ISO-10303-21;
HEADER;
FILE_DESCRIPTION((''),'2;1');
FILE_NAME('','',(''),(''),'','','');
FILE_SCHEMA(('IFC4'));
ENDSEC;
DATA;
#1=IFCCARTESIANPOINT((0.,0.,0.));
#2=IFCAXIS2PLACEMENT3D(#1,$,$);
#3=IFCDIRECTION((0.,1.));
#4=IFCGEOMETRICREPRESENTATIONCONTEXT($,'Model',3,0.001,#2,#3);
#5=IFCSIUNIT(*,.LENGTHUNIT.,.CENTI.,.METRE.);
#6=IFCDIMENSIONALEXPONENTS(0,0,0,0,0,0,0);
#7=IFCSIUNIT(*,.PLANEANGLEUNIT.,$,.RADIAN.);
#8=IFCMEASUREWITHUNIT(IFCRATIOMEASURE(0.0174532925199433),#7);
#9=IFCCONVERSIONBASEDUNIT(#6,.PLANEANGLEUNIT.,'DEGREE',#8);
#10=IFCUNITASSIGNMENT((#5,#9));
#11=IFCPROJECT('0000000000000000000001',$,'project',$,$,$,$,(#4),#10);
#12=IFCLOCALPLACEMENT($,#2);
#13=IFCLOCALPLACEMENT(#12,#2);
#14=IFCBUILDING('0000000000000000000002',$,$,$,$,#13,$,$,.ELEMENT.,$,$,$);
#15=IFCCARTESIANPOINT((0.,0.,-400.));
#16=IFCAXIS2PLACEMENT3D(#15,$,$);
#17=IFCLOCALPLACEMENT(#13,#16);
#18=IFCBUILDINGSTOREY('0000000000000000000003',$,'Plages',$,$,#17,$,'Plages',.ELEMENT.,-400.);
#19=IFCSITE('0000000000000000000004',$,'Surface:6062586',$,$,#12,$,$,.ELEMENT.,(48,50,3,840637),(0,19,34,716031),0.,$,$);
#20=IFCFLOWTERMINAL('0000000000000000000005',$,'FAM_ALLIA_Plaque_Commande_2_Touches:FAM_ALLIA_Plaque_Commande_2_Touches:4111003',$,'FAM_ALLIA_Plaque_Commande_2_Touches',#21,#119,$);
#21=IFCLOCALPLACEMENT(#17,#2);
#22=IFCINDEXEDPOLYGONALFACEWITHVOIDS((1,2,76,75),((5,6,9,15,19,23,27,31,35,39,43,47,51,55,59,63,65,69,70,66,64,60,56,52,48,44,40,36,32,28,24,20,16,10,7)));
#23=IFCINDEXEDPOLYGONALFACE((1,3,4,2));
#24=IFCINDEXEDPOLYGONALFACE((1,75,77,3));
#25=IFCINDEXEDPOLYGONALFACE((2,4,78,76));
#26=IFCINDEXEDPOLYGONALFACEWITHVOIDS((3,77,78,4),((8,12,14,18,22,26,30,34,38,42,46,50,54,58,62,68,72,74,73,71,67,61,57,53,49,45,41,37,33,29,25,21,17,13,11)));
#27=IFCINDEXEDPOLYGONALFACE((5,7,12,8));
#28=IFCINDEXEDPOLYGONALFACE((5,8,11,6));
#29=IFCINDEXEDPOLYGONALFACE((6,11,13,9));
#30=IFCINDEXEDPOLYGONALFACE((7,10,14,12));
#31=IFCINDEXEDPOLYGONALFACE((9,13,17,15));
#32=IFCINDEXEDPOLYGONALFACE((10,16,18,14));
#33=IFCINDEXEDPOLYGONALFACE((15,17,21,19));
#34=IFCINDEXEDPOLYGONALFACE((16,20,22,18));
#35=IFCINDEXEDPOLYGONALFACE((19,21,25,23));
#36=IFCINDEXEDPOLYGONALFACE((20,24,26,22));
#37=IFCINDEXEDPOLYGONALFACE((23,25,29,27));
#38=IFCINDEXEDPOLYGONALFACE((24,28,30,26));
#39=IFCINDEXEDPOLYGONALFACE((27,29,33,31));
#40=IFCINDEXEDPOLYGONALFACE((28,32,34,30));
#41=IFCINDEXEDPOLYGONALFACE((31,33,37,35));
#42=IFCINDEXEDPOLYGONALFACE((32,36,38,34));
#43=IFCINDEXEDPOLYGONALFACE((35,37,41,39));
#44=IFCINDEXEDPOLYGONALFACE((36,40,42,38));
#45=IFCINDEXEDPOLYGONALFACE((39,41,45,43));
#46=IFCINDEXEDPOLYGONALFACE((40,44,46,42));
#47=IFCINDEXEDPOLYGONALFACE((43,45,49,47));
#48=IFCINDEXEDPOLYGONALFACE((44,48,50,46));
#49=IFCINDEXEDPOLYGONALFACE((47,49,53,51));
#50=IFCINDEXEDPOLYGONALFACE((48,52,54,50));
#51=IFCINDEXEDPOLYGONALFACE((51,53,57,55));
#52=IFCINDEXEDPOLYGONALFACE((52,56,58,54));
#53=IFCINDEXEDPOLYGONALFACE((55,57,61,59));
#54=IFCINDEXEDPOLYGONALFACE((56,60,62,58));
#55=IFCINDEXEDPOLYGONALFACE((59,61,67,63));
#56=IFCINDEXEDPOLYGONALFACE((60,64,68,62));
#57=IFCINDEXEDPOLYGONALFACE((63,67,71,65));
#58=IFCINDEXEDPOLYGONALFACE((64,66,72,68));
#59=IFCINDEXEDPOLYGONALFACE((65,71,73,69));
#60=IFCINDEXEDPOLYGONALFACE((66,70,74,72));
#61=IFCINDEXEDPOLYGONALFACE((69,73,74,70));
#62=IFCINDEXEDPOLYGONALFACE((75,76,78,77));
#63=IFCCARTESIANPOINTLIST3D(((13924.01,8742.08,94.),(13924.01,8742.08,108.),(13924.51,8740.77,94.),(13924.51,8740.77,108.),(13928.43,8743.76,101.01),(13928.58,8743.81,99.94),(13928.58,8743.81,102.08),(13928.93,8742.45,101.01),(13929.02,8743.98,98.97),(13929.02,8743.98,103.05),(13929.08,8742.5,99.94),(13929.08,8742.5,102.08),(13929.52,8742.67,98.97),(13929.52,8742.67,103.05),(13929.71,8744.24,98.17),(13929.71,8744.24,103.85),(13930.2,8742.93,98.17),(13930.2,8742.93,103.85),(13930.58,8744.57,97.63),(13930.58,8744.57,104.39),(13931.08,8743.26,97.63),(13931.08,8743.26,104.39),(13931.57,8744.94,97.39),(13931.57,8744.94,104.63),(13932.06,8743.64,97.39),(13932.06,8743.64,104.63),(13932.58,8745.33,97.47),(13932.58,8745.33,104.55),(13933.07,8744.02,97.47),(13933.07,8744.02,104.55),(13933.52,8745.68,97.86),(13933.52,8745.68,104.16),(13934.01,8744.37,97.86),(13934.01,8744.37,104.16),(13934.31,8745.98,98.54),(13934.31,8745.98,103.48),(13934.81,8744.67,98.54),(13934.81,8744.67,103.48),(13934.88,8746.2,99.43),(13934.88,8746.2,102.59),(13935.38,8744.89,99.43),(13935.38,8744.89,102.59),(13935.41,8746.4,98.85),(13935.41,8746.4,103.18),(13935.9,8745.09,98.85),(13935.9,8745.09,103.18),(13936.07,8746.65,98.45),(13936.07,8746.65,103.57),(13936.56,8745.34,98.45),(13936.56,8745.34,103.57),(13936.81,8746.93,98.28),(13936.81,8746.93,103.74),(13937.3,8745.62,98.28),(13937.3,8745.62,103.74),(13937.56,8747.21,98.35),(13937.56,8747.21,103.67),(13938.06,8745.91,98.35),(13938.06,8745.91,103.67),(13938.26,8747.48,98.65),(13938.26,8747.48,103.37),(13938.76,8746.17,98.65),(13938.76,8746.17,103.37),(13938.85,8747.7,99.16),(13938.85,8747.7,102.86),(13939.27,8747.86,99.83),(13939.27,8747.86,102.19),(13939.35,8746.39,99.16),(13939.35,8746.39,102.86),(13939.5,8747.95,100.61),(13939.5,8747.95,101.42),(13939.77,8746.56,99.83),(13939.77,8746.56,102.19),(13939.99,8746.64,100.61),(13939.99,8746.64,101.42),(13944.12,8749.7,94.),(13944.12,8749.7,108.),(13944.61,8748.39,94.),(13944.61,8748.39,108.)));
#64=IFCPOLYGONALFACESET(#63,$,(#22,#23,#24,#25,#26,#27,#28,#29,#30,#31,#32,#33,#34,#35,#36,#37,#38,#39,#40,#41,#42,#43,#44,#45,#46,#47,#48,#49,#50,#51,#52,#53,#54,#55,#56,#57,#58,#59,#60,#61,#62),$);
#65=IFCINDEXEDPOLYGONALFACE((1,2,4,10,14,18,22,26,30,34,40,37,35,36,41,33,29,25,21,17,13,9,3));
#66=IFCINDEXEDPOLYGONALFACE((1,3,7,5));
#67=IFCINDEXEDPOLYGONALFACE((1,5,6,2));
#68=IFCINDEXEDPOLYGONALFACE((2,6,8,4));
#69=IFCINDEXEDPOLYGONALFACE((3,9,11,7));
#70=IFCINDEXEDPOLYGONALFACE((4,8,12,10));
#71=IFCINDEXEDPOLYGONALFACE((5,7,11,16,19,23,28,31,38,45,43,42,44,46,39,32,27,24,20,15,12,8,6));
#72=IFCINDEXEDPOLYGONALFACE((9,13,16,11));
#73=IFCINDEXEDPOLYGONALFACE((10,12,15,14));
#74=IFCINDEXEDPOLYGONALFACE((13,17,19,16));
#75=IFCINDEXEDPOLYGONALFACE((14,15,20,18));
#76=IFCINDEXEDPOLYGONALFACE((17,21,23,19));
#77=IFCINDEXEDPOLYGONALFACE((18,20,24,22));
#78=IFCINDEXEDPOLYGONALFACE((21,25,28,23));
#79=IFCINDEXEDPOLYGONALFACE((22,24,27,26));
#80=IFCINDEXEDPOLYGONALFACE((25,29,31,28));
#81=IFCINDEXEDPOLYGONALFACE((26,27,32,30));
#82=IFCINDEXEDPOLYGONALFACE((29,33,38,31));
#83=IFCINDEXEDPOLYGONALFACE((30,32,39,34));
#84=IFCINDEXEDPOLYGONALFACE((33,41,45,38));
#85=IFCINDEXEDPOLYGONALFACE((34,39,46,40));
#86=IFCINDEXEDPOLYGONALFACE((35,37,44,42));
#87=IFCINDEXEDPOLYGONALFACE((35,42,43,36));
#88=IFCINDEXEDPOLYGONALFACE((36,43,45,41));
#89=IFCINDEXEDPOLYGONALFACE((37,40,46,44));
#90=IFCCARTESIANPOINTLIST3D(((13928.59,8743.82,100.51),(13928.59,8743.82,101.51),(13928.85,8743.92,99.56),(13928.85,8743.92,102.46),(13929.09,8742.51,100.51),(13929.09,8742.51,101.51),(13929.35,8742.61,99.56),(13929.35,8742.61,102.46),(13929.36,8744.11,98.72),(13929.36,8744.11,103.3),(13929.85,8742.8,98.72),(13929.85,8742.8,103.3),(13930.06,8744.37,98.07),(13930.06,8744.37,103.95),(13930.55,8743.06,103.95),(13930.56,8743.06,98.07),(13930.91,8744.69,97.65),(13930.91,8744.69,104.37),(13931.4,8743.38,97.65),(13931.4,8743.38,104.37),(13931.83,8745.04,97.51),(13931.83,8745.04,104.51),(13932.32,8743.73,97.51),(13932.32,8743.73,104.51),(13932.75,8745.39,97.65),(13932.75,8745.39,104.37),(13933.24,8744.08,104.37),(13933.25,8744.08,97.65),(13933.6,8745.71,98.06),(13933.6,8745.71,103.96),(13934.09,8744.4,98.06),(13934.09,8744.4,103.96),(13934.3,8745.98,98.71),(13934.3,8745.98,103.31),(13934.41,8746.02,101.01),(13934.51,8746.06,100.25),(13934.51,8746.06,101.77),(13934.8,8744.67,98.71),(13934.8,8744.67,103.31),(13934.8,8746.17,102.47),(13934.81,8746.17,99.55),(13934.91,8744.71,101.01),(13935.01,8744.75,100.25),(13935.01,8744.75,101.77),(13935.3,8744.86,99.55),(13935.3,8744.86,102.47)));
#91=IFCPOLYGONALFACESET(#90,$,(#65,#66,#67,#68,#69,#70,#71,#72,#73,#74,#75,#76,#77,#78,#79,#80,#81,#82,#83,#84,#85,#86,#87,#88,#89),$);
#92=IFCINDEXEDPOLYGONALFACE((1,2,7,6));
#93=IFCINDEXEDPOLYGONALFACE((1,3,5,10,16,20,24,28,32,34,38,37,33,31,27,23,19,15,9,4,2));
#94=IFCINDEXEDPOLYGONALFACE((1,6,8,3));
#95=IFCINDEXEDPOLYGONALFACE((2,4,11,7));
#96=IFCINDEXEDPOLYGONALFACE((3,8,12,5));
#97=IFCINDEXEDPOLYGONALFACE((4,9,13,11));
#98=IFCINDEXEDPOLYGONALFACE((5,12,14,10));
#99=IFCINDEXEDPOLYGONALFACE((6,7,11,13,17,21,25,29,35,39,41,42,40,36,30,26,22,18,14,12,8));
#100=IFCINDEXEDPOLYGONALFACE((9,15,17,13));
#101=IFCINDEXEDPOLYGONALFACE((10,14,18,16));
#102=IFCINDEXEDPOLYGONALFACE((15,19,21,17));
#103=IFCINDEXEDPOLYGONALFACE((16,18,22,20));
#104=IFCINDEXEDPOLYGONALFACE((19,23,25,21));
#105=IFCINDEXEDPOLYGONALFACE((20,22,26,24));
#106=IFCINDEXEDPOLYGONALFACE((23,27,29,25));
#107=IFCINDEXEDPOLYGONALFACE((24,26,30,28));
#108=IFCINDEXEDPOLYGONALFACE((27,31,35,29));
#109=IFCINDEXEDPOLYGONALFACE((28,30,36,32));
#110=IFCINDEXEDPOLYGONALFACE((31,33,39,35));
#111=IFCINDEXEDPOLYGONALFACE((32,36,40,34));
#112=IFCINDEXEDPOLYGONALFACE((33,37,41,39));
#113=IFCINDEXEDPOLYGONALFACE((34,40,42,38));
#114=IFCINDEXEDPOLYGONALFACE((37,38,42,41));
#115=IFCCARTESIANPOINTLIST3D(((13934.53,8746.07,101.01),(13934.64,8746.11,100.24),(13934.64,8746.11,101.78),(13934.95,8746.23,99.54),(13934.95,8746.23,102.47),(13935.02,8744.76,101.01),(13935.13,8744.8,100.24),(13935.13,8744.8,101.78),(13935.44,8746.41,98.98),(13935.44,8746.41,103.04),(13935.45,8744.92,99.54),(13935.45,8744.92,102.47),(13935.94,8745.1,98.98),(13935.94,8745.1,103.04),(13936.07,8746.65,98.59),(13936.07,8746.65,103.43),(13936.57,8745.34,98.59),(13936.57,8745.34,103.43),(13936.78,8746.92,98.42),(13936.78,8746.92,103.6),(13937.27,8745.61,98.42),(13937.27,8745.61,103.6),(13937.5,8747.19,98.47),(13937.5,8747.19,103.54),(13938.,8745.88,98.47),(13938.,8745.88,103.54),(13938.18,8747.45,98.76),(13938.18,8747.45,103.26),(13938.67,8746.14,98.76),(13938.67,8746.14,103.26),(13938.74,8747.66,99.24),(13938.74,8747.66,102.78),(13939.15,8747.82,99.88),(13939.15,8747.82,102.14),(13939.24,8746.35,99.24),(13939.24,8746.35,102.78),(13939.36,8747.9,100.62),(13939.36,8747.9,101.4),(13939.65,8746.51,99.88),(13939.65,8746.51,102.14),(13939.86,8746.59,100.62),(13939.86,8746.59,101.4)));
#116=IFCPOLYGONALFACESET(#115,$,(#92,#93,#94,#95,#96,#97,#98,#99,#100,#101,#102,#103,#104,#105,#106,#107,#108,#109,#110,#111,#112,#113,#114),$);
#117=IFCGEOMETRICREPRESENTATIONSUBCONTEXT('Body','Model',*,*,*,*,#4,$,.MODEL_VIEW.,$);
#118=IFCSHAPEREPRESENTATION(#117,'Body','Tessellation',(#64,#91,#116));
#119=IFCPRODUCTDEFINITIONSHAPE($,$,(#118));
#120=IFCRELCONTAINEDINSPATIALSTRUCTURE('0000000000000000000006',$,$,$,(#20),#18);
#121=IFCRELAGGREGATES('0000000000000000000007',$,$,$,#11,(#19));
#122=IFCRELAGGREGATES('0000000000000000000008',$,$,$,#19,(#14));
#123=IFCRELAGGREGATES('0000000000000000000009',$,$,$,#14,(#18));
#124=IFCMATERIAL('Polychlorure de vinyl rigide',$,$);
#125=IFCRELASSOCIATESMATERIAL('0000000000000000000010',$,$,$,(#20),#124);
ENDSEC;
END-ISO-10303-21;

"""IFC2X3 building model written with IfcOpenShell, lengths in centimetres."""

from ifc_helpers import new_model, entity, si_unit, converted_unit, direction, frame, frame_2d, origin, place, context, subcontext, project, spatial, polyline, circle_curve, parameter, trimmed, segment, composite_curve, circle, outline, extrude, source, transform, mapped, material, element, save


model = new_model("IFC2X3")

# Units and contexts
model_context = context("Model", 3, precision=0.001, world=origin(), true_north=direction((0.0, 1.0)))
body_context = subcontext(model_context, "Body", "Model", "MODEL_VIEW")
ifc_project = project(units=[si_unit("LENGTHUNIT", "METRE", prefix="CENTI"), converted_unit("PLANEANGLEUNIT", "DEGREE", entity("IfcRatioMeasure", 0.0174532925199433), si_unit("PLANEANGLEUNIT", "RADIAN"), dimensions=[0, 0, 0, 0, 0, 0, 0])], contexts=[model_context])

# Site, building, storey
site_placement = place(None, origin())
site = spatial("IfcSite", under=ifc_project, at=site_placement, Name="Surface:6062586", CompositionType="ELEMENT", RefLatitude=(48, 50, 3, 840637), RefLongitude=(0, 19, 34, 716031), RefElevation=0.0)
building_placement = place(site_placement, origin())
building = spatial("IfcBuilding", under=site, at=building_placement, CompositionType="ELEMENT")
storey_placement = place(building_placement, frame((0.0, 0.0, -400.0)))
storey = spatial("IfcBuildingStorey", under=building, at=storey_placement, Name="Plages", LongName="Plages", CompositionType="ELEMENT", Elevation=-400.0)

# Flow terminal
ifc_material_1 = material(Name="Polychlorure de vinyl rigide")
shared_shape_1 = source(origin(), body_context, "Body", "SweptSolid", [
    extrude(outline(polyline([(-10.75, -7.0), (10.75, -7.0), (10.75, 7.0), (-10.75, 7.0), (-10.75, -7.0)]), holes=[composite_curve([segment(trimmed(circle_curve(frame_2d((-3.1, 0.01), x_axis=(-1.0, 0.0)), 2.73), [parameter(215.328783)], [parameter(144.671217)], True, "PARAMETER"), False, "CONTINUOUS"), segment(trimmed(circle_curve(frame_2d((2.39, 0.01), x_axis=(-1.0, 0.0)), 3.63), [parameter(25.817037)], [parameter(334.182963)], True, "PARAMETER"), False, "CONTINUOUS")], self_intersect=False)]), frame((10.75, 0.0, 7.0), z_axis=(0.0, 1.0, 0.0), x_axis=(-1.0, 0.0, 0.0)), (0.0, 0.0, 1.0), 1.4),
    extrude(outline(composite_curve([segment(trimmed(circle_curve(frame_2d((-3.18, 0.0), x_axis=(1.0, 0.0)), 3.5), [parameter(24.630749)], [parameter(335.341392)], True, "PARAMETER"), True, "CONTINUOUS"), segment(trimmed(circle_curve(frame_2d((2.31, 0.0), x_axis=(1.0, 0.0)), 2.73), [parameter(147.719336)], [parameter(212.252805)], True, "PARAMETER"), False, "CONTINUOUS")], self_intersect=False)), frame((11.54, 0.0, 7.01), z_axis=(0.0, 1.0, 0.0), x_axis=(1.0, 0.0, 0.0)), (0.0, 0.0, 1.0), 1.4),
    extrude(circle(Radius=2.6, at=frame_2d((0.0, 0.0), x_axis=(1.0, 0.0))), frame((13.85, 0.0, 7.01), z_axis=(0.0, 1.0, 0.0), x_axis=(-1.0, 0.0, 0.0)), (0.0, 0.0, 1.0), 1.4),
])
for number, where, z_axis, x_axis, name in (
    (1, (13924.51, 8740.77, 94.0), (0.0, 0.0, 1.0), (0.935103, 0.354376, 0.0), "FAM_ALLIA_Plaque_Commande_2_Touches:FAM_ALLIA_Plaque_Commande_2_Touches:4111003"),
):
    element("IfcFlowTerminal", number, at=place(storey_placement, frame(where, z_axis=z_axis, x_axis=x_axis)), inside=storey, material=ifc_material_1, Name=name, ObjectType="FAM_ALLIA_Plaque_Commande_2_Touches", context=body_context, shape_type="MappedRepresentation", body=[
        mapped(shared_shape_1, transform((0.0, 0.0, 0.0), scale=1.0)),
    ])

save(model, "model.ifc")
